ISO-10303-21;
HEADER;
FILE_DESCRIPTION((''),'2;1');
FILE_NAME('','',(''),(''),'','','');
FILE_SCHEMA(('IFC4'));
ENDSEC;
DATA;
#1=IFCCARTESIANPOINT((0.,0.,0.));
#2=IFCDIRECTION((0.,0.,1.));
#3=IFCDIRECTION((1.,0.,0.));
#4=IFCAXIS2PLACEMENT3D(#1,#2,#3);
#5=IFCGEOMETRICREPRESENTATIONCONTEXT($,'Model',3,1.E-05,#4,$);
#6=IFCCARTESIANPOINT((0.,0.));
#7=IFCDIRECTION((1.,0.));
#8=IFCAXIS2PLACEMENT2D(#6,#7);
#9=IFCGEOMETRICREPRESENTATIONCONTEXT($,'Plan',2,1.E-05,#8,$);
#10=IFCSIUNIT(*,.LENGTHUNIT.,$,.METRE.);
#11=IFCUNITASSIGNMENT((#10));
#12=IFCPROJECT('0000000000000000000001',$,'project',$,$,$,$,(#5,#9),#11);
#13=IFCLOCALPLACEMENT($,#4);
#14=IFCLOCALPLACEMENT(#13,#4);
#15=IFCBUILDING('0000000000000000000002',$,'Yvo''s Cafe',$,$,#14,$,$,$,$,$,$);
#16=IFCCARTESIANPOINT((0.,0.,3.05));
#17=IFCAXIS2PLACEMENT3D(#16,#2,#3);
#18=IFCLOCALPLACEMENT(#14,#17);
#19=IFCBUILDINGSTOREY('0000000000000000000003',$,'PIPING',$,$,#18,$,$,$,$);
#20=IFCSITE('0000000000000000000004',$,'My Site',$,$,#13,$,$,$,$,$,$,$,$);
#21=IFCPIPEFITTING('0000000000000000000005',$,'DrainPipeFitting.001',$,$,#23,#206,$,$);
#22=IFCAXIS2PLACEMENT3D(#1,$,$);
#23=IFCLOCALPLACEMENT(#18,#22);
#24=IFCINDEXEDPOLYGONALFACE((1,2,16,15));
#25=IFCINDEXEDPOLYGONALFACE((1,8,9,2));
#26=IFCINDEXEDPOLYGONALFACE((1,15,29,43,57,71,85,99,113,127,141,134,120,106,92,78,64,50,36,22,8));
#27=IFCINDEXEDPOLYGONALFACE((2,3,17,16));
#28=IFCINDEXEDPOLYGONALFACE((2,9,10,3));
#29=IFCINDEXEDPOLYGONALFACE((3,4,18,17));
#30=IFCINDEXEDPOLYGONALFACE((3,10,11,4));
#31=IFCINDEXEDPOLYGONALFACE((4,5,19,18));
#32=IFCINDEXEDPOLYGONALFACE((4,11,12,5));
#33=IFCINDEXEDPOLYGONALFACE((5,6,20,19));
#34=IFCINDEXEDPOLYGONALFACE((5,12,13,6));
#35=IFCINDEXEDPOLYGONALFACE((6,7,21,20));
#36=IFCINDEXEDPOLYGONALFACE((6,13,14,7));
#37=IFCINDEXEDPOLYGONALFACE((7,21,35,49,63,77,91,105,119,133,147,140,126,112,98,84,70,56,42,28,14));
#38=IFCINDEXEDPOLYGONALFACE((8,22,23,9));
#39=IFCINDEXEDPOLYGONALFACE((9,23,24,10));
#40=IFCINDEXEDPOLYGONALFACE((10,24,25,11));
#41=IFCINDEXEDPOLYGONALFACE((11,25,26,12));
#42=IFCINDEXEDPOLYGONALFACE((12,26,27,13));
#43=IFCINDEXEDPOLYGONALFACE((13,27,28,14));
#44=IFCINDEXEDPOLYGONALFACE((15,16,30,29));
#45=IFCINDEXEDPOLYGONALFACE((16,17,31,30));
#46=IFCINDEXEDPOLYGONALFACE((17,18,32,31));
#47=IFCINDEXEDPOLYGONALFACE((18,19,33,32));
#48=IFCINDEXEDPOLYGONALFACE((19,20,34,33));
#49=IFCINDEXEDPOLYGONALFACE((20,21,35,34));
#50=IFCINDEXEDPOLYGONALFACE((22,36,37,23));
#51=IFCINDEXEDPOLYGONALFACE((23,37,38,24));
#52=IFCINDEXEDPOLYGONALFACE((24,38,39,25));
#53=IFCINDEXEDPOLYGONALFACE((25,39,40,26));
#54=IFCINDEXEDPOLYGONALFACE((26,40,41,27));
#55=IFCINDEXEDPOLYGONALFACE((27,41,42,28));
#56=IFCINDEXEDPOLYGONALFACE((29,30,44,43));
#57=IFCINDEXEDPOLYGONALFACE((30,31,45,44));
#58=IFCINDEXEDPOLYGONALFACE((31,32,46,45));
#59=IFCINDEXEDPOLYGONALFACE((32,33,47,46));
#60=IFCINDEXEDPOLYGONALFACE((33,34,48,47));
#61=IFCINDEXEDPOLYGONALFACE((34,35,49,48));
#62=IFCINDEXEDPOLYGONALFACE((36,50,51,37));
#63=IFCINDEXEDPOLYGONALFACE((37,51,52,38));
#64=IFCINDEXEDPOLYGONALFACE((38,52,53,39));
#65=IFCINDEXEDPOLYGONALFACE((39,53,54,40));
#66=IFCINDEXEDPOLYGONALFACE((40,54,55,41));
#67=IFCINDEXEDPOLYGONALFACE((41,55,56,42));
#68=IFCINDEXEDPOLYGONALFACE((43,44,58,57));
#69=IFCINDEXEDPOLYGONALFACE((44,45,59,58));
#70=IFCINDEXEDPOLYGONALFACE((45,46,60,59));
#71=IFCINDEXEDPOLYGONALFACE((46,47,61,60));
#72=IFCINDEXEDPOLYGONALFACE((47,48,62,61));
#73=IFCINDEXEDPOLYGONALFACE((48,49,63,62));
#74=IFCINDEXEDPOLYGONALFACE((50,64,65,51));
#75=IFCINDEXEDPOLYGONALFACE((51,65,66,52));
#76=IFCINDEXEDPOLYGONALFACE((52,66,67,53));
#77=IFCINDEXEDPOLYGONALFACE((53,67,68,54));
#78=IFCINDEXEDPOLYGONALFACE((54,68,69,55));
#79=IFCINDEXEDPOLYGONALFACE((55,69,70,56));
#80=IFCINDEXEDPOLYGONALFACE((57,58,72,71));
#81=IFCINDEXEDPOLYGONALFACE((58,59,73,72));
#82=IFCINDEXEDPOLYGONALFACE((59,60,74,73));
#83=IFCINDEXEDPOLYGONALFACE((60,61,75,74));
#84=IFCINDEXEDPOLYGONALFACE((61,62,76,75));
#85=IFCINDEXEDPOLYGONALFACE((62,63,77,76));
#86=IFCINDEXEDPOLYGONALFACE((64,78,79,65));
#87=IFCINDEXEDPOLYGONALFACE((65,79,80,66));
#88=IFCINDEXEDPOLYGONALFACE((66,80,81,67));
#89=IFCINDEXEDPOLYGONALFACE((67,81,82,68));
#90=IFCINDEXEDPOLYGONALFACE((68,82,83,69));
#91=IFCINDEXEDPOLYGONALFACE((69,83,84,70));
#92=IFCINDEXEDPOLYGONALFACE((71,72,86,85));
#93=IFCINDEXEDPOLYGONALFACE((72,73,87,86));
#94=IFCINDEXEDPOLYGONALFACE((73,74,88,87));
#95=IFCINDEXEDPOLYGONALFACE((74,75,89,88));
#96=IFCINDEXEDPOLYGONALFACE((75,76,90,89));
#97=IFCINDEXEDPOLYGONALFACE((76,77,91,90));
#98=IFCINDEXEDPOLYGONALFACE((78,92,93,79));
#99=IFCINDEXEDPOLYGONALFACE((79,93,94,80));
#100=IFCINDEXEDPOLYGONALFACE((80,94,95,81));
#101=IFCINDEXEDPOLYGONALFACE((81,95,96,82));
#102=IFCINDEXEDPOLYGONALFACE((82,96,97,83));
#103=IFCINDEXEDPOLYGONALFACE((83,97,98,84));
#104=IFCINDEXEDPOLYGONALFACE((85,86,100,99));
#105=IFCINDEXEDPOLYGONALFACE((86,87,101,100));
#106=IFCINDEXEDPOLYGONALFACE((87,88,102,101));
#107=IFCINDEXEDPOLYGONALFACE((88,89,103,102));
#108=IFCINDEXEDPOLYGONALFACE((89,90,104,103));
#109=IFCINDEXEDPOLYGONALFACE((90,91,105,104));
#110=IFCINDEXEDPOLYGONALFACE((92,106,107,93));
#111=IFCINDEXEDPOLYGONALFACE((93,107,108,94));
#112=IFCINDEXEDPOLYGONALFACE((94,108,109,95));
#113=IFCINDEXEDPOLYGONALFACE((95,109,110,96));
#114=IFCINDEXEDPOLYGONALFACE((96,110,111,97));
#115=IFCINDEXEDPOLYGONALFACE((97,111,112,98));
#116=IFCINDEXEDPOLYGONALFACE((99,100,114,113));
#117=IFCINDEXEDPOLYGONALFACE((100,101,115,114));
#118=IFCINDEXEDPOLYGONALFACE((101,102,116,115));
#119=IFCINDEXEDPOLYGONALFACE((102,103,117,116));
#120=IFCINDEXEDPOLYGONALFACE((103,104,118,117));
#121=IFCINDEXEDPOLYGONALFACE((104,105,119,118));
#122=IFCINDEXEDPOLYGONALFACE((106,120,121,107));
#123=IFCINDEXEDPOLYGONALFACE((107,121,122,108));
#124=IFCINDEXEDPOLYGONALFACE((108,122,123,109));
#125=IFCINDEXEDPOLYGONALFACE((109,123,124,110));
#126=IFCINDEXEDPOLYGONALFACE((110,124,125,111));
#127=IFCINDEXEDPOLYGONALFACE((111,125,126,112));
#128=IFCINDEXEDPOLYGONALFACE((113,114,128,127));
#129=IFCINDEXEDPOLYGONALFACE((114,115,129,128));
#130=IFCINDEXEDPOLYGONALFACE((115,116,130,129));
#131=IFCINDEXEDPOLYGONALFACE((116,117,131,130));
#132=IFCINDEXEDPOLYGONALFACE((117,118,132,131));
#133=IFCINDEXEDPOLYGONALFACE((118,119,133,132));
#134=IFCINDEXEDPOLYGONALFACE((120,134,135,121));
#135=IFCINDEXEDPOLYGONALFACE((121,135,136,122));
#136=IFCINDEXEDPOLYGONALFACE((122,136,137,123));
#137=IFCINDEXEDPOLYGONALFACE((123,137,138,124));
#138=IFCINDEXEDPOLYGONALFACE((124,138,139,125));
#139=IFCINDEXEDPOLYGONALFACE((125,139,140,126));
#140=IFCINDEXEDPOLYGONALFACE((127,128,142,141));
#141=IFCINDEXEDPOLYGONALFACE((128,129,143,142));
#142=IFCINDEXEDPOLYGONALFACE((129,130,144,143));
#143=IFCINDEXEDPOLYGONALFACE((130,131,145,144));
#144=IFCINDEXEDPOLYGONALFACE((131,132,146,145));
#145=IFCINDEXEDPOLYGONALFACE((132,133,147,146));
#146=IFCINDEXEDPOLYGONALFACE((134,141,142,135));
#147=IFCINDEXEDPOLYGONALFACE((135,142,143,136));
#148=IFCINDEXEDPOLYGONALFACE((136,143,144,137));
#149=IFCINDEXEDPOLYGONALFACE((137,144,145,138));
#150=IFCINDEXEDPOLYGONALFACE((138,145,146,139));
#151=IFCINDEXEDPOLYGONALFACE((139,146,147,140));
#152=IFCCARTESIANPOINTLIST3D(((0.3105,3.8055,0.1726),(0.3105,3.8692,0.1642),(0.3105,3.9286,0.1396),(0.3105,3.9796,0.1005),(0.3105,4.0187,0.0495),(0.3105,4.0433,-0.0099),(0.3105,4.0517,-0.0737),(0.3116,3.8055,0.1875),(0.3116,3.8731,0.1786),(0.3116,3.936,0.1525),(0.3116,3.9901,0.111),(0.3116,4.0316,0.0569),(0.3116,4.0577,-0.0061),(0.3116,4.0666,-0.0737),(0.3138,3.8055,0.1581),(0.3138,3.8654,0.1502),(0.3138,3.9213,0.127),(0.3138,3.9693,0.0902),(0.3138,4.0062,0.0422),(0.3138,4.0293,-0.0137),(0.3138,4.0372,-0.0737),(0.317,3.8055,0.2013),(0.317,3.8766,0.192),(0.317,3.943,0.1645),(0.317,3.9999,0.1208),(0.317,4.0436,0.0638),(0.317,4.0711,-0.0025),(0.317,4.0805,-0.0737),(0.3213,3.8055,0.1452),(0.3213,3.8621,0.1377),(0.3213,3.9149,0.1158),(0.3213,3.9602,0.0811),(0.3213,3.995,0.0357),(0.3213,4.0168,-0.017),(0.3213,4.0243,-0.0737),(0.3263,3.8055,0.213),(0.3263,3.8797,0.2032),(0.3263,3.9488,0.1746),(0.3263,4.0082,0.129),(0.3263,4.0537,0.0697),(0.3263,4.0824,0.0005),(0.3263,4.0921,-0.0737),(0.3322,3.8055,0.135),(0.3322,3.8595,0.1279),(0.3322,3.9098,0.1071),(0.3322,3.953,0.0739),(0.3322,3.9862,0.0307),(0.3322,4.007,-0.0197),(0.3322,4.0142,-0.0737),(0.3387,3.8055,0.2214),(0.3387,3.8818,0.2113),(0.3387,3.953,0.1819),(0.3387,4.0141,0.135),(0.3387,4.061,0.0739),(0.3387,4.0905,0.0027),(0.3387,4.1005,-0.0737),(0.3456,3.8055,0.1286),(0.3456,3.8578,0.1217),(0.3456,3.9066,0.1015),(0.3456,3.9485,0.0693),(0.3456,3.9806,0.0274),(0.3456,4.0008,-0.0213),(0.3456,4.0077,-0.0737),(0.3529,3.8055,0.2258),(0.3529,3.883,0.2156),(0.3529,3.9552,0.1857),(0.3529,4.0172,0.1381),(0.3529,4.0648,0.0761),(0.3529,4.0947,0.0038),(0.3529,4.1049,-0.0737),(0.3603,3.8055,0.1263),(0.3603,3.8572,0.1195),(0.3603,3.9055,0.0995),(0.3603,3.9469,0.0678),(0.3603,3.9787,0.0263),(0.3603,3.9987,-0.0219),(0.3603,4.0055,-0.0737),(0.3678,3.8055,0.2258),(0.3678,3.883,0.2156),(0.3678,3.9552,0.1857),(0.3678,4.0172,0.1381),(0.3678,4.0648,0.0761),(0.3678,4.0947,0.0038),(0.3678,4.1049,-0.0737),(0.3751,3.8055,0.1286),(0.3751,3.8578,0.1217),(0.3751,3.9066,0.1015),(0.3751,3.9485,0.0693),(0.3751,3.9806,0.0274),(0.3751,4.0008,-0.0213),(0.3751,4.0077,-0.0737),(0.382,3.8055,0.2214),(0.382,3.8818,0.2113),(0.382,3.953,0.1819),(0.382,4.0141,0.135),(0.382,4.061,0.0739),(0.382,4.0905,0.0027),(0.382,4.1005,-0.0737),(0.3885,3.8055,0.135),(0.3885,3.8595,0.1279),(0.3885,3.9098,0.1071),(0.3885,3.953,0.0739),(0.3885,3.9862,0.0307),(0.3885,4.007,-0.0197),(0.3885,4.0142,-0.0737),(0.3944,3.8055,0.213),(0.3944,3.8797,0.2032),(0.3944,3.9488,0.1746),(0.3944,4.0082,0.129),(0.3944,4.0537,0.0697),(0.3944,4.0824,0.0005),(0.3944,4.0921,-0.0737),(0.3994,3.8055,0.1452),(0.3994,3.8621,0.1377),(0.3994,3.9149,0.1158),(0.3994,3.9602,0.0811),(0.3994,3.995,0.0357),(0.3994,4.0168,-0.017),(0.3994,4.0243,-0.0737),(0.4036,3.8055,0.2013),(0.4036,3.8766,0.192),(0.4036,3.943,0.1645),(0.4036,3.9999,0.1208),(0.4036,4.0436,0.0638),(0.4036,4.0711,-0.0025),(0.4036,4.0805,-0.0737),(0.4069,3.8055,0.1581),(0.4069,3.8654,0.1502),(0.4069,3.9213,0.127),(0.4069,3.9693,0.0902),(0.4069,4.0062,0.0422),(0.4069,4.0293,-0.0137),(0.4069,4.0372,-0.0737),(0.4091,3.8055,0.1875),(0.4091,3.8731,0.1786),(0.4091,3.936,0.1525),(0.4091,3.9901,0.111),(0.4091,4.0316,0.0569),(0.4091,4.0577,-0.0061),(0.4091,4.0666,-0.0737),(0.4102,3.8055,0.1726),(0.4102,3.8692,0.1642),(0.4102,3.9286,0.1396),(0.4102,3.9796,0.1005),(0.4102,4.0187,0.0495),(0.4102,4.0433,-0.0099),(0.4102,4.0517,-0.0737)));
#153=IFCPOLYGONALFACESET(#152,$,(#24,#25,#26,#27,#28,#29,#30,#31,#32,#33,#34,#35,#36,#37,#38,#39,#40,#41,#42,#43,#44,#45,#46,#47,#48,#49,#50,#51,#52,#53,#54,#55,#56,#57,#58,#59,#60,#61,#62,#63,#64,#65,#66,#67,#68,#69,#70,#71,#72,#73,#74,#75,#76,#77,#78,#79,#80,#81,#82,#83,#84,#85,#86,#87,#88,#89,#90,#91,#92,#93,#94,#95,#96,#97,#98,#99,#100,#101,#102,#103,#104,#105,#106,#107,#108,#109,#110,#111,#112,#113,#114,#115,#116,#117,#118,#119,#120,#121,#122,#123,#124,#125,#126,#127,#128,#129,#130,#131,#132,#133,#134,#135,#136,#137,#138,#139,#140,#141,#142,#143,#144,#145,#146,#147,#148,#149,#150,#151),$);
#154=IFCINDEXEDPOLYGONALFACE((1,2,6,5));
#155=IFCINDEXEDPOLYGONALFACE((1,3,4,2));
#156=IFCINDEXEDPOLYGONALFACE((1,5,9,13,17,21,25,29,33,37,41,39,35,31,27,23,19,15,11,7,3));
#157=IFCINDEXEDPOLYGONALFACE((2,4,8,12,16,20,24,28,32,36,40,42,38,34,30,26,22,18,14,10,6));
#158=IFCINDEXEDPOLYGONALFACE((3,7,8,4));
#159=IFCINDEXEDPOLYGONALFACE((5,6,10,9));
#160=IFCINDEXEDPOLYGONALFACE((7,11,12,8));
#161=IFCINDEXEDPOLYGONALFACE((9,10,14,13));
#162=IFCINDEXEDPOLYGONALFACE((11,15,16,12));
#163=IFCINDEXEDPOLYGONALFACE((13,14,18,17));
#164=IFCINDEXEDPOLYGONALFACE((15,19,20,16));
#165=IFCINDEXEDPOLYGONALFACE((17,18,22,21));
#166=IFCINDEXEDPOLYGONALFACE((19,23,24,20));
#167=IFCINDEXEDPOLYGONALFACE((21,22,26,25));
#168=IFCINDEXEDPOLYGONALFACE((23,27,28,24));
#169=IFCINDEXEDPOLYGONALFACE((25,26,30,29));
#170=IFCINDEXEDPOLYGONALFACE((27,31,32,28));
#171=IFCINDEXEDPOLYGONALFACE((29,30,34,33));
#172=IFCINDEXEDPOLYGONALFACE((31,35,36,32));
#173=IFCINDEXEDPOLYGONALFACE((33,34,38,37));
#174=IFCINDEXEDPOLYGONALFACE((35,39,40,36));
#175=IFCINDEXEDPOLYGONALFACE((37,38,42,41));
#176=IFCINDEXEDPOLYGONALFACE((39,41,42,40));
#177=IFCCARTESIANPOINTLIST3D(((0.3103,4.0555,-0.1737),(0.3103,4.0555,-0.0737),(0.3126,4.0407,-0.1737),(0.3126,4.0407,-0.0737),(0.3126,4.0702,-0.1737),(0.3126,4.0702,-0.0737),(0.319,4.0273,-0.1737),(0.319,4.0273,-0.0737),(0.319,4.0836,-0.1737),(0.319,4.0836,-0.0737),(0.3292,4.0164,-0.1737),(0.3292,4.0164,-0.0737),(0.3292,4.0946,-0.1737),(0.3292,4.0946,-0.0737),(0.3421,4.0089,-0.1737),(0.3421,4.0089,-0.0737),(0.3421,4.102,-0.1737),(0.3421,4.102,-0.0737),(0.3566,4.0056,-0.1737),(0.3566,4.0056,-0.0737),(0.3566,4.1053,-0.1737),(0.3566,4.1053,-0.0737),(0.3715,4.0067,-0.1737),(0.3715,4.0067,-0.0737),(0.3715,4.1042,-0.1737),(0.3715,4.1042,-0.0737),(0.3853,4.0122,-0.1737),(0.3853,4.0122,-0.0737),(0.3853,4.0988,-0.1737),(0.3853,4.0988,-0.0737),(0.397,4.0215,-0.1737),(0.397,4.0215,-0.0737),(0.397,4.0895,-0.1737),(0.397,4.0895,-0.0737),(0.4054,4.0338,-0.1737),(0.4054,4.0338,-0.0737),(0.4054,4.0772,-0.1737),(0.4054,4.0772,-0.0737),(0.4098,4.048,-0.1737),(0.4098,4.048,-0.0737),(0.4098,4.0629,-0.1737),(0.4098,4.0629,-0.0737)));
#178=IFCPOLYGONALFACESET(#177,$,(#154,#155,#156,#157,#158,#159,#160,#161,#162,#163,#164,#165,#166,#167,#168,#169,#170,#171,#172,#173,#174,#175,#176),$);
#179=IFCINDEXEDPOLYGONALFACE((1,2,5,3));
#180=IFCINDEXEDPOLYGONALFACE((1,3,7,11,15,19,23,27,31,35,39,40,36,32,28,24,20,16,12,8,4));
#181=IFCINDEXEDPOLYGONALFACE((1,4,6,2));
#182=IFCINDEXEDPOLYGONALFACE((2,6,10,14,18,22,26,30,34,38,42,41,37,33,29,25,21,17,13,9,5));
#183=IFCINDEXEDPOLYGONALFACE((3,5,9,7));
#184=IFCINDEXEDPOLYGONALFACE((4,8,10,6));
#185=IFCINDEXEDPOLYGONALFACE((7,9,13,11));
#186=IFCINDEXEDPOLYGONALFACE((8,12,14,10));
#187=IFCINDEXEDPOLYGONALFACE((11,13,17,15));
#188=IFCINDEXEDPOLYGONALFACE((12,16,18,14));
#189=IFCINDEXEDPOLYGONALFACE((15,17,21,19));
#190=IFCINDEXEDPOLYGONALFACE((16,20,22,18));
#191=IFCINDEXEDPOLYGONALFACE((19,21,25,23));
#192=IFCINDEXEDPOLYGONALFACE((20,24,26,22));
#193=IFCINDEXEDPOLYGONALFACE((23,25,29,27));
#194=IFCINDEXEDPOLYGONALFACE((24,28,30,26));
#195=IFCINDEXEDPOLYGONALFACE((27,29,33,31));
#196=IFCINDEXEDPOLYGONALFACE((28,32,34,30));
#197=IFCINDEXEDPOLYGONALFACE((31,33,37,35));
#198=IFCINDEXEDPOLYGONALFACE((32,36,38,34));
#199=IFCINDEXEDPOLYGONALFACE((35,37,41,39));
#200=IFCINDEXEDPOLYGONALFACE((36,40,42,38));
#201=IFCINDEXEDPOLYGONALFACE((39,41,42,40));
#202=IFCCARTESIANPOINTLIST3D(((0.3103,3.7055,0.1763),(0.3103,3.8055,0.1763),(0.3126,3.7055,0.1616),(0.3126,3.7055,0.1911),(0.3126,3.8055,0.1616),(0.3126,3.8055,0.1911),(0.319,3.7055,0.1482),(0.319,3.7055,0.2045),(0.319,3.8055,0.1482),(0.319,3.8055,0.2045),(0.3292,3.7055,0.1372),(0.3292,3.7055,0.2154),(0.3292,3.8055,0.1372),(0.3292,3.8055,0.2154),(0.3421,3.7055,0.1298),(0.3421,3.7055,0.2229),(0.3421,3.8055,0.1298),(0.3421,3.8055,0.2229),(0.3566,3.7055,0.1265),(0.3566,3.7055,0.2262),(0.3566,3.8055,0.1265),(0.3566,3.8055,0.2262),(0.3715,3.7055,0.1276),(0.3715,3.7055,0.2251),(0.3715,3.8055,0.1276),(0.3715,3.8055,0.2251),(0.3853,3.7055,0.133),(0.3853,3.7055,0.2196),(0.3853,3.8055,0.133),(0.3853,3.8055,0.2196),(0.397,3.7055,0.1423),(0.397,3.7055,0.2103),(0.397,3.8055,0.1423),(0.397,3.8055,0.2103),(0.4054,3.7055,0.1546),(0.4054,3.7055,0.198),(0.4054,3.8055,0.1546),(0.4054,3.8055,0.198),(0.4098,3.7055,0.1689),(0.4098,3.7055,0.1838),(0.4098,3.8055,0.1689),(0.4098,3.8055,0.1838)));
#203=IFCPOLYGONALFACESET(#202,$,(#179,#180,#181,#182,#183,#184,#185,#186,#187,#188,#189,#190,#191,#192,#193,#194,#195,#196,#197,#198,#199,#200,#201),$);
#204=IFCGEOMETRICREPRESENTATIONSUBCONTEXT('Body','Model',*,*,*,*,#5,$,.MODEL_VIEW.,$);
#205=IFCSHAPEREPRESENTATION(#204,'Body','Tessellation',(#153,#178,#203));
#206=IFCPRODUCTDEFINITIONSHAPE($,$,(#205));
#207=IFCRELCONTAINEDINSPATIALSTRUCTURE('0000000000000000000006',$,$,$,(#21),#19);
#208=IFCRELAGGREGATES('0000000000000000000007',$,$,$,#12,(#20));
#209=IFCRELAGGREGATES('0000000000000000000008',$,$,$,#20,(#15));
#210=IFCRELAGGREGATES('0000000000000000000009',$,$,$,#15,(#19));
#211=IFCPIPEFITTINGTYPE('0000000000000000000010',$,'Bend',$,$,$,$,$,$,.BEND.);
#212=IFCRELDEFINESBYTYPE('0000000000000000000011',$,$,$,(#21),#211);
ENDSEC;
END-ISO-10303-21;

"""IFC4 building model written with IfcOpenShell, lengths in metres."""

from ifc_helpers import new_model, entity, si_unit, frame, origin_with_axes, origin_2d_with_axis, place, context, subcontext, project, spatial, circle, extrude, source, transform, mapped, type_object, type_shapes, element, save


model = new_model("IFC4")

# Units and contexts
model_context = context("Model", 3, precision=1e-05, world=origin_with_axes())
plan_context = context("Plan", 2, precision=1e-05, world=origin_2d_with_axis())
body_context = subcontext(model_context, "Body", "Model", "MODEL_VIEW")
ifc_project = project(units=[si_unit("LENGTHUNIT", "METRE")], contexts=[model_context, plan_context])

# Site, building, storey
site_placement = place(None, origin_with_axes())
site = spatial("IfcSite", under=ifc_project, at=site_placement, Name="My Site")
building_placement = place(site_placement, origin_with_axes())
building = spatial("IfcBuilding", under=site, at=building_placement, Name="Yvo's Cafe")
storey_placement = place(building_placement, frame((0.0, 0.0, 3.05), z_axis=(0.0, 0.0, 1.0), x_axis=(1.0, 0.0, 0.0)))
storey = spatial("IfcBuildingStorey", under=building, at=storey_placement, Name="PIPING")

# Shared definitions
pipe_fitting_type_1 = type_object("IfcPipeFittingType", Name="Bend", PredefinedType="BEND")
shared_shape_1 = source(origin_with_axes(), body_context, "Body", "SolidModel", [
    entity("IfcSweptDiskSolid", entity("IfcIndexedPolyCurve", entity("IfcCartesianPointList3D", [[0.0, 0.0, -0.1], [0.0, -0.0732, -0.2768], [0.0, -0.25, -0.35]]), [entity("IfcArcIndex", [1, 2, 3])]), 0.05),
    extrude(circle(Radius=0.05), origin_with_axes(), (0.0, 0.0, -1.0), 0.1),
    extrude(circle(Radius=0.05), frame((0.0, -0.25, -0.35), z_axis=(0.0, -1.0, 0.0), x_axis=(1.0, 0.0, 0.0)), (0.0, 0.0, 1.0), 0.1),
])
type_shapes(pipe_fitting_type_1, [shared_shape_1])

# Pipe fitting
for number, where, z_axis, x_axis, name in (
    (1, (0.3603, 4.0555, -0.1737), (0.0, 0.0, -1.0), (-1.0, 0.0, 0.0), "DrainPipeFitting.001"),
):
    element("IfcPipeFitting", number, at=place(storey_placement, frame(where, z_axis=z_axis, x_axis=x_axis)), inside=storey, type_object=pipe_fitting_type_1, Name=name, context=body_context, shape_type="MappedRepresentation", body=[
        mapped(shared_shape_1, transform((0.0, 0.0, 0.0), x_axis=(1.0, 0.0, 0.0), y_axis=(0.0, 1.0, 0.0), z_axis=(0.0, 0.0, 1.0), scale=1.0)),
    ])

save(model, "model.ifc")
